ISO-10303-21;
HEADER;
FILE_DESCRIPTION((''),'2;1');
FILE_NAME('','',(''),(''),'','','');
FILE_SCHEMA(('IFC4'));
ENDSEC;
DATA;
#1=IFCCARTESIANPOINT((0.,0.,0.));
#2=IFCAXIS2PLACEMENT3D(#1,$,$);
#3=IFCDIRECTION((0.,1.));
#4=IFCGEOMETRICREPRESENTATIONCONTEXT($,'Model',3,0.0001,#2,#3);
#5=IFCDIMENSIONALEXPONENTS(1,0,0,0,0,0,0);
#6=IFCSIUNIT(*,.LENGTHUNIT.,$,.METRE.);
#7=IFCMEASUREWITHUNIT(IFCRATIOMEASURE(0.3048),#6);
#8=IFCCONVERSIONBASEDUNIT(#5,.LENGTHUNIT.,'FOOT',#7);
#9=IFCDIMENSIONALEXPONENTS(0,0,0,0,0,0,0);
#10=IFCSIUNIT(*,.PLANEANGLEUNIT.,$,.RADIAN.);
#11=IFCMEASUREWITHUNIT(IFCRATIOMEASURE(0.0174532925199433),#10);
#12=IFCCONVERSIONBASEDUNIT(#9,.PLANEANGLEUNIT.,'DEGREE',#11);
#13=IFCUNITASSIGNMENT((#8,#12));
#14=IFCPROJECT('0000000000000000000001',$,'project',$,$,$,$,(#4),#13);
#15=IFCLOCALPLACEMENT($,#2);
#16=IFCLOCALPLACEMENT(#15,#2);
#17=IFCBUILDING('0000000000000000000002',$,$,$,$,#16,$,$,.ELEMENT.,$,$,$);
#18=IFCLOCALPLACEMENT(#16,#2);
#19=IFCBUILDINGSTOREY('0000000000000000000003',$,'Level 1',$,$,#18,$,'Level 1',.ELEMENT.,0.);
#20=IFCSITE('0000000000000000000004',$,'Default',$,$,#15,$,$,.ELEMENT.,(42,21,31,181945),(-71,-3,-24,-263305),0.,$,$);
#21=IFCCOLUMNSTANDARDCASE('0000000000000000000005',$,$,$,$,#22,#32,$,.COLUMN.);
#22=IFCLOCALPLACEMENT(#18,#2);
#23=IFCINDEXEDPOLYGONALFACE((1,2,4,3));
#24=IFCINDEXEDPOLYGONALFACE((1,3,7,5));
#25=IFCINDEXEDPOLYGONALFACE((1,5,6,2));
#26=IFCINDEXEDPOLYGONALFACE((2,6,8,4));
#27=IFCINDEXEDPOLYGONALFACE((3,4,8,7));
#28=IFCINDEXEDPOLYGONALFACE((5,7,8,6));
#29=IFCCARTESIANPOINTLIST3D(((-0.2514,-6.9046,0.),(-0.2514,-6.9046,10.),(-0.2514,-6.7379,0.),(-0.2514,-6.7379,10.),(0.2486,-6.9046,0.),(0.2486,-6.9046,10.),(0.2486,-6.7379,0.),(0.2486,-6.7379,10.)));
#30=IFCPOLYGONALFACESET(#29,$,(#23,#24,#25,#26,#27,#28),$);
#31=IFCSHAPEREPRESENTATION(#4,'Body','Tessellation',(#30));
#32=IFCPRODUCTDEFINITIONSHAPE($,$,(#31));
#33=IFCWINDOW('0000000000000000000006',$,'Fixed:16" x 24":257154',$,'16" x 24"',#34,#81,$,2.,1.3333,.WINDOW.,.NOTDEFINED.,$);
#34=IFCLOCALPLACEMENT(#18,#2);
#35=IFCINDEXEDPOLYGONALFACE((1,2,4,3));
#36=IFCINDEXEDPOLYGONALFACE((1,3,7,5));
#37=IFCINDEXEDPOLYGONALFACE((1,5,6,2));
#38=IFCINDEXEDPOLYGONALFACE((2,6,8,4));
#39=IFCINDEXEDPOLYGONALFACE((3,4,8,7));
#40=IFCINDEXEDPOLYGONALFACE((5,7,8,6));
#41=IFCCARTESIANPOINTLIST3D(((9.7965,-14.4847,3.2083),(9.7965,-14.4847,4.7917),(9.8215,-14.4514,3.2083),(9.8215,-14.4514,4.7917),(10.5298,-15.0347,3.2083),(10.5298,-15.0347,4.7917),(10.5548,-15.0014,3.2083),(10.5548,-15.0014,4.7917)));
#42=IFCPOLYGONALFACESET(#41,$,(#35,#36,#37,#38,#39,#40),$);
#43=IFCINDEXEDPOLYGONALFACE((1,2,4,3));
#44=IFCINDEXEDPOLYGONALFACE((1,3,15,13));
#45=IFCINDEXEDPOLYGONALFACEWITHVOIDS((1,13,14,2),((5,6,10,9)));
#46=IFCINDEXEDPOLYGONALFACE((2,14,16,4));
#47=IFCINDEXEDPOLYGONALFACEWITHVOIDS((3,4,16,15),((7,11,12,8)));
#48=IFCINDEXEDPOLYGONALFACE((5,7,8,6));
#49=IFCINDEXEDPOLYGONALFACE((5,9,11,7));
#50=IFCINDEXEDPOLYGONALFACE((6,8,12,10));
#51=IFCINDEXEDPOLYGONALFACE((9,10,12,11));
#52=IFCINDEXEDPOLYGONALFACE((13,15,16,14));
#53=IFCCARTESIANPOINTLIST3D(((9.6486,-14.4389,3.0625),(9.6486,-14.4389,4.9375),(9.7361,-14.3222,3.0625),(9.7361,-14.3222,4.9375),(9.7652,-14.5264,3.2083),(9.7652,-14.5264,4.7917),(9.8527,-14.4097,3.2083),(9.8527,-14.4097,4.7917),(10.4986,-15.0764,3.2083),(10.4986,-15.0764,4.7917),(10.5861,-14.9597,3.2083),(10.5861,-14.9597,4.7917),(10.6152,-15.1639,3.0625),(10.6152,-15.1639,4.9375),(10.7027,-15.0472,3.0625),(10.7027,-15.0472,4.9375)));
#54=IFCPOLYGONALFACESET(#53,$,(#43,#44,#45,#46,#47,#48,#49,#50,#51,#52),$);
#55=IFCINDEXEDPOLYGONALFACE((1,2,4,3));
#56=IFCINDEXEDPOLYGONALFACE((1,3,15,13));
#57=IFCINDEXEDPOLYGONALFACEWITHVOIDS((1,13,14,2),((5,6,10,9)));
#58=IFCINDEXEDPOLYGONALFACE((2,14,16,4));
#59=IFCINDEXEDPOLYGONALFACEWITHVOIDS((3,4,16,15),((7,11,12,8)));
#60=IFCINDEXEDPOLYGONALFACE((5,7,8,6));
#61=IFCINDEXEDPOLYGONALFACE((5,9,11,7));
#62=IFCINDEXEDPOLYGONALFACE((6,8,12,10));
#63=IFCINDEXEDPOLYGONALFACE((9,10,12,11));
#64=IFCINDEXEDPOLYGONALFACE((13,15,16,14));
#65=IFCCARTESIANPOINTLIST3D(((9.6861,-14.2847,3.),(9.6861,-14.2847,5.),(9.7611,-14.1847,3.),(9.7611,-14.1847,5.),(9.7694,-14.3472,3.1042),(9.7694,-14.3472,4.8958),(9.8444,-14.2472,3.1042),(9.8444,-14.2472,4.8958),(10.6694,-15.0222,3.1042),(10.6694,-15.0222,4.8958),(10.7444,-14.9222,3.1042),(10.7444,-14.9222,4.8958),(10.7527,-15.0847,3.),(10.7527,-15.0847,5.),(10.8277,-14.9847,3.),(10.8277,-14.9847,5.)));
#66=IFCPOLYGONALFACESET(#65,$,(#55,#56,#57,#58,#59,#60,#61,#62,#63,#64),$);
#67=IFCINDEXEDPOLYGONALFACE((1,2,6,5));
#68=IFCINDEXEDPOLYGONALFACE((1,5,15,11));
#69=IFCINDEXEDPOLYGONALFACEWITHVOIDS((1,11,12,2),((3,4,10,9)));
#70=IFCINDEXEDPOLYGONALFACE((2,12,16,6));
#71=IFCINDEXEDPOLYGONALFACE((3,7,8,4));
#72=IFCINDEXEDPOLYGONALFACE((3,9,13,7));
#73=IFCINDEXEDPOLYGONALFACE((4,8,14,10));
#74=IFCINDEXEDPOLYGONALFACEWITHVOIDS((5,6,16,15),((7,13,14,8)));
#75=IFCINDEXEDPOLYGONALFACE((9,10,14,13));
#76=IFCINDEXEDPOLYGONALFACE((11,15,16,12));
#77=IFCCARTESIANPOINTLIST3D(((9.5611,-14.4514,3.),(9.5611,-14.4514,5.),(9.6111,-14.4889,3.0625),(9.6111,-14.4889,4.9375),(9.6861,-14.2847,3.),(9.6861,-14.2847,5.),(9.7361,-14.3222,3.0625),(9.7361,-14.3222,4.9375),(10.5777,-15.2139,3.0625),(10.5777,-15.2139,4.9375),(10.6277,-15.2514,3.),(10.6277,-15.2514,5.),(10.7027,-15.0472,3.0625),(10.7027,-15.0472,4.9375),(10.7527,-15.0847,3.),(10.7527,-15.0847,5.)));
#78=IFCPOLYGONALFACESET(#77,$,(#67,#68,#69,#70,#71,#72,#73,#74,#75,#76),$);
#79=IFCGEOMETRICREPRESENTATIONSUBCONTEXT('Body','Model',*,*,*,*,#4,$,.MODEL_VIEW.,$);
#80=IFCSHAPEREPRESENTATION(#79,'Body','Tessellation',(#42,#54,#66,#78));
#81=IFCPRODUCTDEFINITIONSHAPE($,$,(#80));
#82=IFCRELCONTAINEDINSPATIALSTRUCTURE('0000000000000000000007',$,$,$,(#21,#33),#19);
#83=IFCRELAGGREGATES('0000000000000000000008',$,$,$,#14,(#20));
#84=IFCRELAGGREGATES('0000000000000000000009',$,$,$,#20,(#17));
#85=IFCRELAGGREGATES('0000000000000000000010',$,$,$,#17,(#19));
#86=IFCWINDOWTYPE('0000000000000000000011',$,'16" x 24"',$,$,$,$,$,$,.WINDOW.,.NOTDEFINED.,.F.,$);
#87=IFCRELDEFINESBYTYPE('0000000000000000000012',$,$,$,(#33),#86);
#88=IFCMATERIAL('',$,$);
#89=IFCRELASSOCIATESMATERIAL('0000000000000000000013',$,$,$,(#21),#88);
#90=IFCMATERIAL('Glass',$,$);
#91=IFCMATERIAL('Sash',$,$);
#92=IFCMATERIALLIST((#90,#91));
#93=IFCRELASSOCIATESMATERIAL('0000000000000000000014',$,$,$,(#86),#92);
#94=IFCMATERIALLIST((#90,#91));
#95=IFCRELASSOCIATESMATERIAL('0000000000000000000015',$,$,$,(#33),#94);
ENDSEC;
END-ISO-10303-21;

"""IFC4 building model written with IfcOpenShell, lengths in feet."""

from ifc_helpers import new_model, entity, si_unit, converted_unit, direction, frame, origin, origin_2d_with_axis, place, context, subcontext, project, spatial, polyline, rectangle, outline, extrude, source, transform, mapped, material, material_list, type_object, type_shapes, element, save


model = new_model("IFC4")

# Units and contexts
model_context = context("Model", 3, precision=0.0001, world=origin(), true_north=direction((0.0, 1.0)))
body_context = subcontext(model_context, "Body", "Model", "MODEL_VIEW")
ifc_project = project(units=[converted_unit("LENGTHUNIT", "FOOT", entity("IfcRatioMeasure", 0.3048), si_unit("LENGTHUNIT", "METRE"), dimensions=[1, 0, 0, 0, 0, 0, 0]), converted_unit("PLANEANGLEUNIT", "DEGREE", entity("IfcRatioMeasure", 0.0174532925199433), si_unit("PLANEANGLEUNIT", "RADIAN"), dimensions=[0, 0, 0, 0, 0, 0, 0])], contexts=[model_context])

# Site, building, storey
site_placement = place(None, origin())
site = spatial("IfcSite", under=ifc_project, at=site_placement, Name="Default", CompositionType="ELEMENT", RefLatitude=(42, 21, 31, 181945), RefLongitude=(-71, -3, -24, -263305), RefElevation=0.0)
building_placement = place(site_placement, origin())
building = spatial("IfcBuilding", under=site, at=building_placement, CompositionType="ELEMENT")
storey_placement = place(building_placement, origin())
storey = spatial("IfcBuildingStorey", under=building, at=storey_placement, Name="Level 1", LongName="Level 1", CompositionType="ELEMENT", Elevation=0.0)

# Column
ifc_material_1 = material(Name="")
placement_1 = place(storey_placement, frame((-0.0014, -6.9045, 0.0), z_axis=(0.0, 0.0, 1.0), x_axis=(0.0, 1.0, 0.0)))
for number, where, z_axis, x_axis in (
    (1, (0.0833, 0.0, 0.0), (0.0, 0.0, 1.0), (1.0, 0.0, 0.0)),
):
    element("IfcColumnStandardCase", number, at=place(placement_1, frame(where, z_axis=z_axis, x_axis=x_axis)), inside=storey, material=ifc_material_1, PredefinedType="COLUMN", context=model_context, shape_type="SweptSolid", body=[
        extrude(rectangle(XDim=0.1667, YDim=0.5), origin(), (0.0, 0.0, 1.0), 10.0),
    ])

# Window
ifc_material_2 = material(Name="Glass")
ifc_material_3 = material(Name="Sash")
ifc_material_list_1 = material_list([ifc_material_2, ifc_material_3])
ifc_material_list_2 = material_list([ifc_material_2, ifc_material_3])
window_type = type_object("IfcWindowType", Name="16\" x 24\"", ParameterTakesPrecedence=False, PartitioningType="NOTDEFINED", PredefinedType="WINDOW", material=ifc_material_list_2)
shared_shape = source(origin(), body_context, "Body", "SweptSolid", [
    extrude(rectangle(XDim=0.0417, YDim=0.9167, at=origin_2d_with_axis()), frame((0.6667, 0.1979, 0.2083), z_axis=(0.0, 0.0, 1.0), x_axis=(0.0, 1.0, 0.0)), (0.0, 0.0, 1.0), 1.5833),
    extrude(outline(polyline([(-0.6042, -0.9375), (0.6042, -0.9375), (0.6042, 0.9375), (-0.6042, 0.9375), (-0.6042, -0.9375)]), holes=[polyline([(-0.4583, -0.7917), (-0.4583, 0.7917), (0.4583, 0.7917), (0.4583, -0.7917), (-0.4583, -0.7917)])]), frame((0.6667, 0.125, 1.0), z_axis=(0.0, 1.0, 0.0), x_axis=(1.0, 0.0, 0.0)), (0.0, 0.0, 1.0), 0.1458),
    extrude(outline(polyline([(-0.6667, -1.0), (0.6667, -1.0), (0.6667, 1.0), (-0.6667, 1.0), (-0.6667, -1.0)]), holes=[polyline([(-0.5625, -0.8958), (-0.5625, 0.8958), (0.5625, 0.8958), (0.5625, -0.8958), (-0.5625, -0.8958)])]), frame((0.6667, 0.0, 1.0), z_axis=(0.0, 1.0, 0.0), x_axis=(1.0, 0.0, 0.0)), (0.0, 0.0, 1.0), 0.125),
    extrude(outline(polyline([(-1.0, -0.6667), (1.0, -0.6667), (1.0, 0.6667), (-1.0, 0.6667), (-1.0, -0.6667)]), holes=[polyline([(-0.9375, -0.6042), (-0.9375, 0.6042), (0.9375, 0.6042), (0.9375, -0.6042), (-0.9375, -0.6042)])]), frame((0.6667, 0.125, 1.0), z_axis=(0.0, 1.0, 0.0), x_axis=(0.0, 0.0, -1.0)), (0.0, 0.0, 1.0), 0.2083),
])
type_shapes(window_type, [shared_shape])
placement_2 = place(storey_placement, frame((47.9059, -43.0017, 0.0), z_axis=(0.0, 0.0, 1.0), x_axis=(-0.8, 0.6, 0.0)))
placement_3 = place(placement_2, frame((46.4728, -0.1667, 3.0)))
window_placement = place(placement_3, origin())
element("IfcWindow", 2, at=window_placement, inside=storey, type_object=window_type, material=ifc_material_list_1, Name="Fixed:16\" x 24\":257154", ObjectType="16\" x 24\"", OverallHeight=2.0, OverallWidth=1.3333, PartitioningType="NOTDEFINED", PredefinedType="WINDOW", context=body_context, shape_type="MappedRepresentation", body=[
    mapped(shared_shape, transform((0.0, 0.0, 0.0), scale=1.0)),
])

save(model, "model.ifc")
